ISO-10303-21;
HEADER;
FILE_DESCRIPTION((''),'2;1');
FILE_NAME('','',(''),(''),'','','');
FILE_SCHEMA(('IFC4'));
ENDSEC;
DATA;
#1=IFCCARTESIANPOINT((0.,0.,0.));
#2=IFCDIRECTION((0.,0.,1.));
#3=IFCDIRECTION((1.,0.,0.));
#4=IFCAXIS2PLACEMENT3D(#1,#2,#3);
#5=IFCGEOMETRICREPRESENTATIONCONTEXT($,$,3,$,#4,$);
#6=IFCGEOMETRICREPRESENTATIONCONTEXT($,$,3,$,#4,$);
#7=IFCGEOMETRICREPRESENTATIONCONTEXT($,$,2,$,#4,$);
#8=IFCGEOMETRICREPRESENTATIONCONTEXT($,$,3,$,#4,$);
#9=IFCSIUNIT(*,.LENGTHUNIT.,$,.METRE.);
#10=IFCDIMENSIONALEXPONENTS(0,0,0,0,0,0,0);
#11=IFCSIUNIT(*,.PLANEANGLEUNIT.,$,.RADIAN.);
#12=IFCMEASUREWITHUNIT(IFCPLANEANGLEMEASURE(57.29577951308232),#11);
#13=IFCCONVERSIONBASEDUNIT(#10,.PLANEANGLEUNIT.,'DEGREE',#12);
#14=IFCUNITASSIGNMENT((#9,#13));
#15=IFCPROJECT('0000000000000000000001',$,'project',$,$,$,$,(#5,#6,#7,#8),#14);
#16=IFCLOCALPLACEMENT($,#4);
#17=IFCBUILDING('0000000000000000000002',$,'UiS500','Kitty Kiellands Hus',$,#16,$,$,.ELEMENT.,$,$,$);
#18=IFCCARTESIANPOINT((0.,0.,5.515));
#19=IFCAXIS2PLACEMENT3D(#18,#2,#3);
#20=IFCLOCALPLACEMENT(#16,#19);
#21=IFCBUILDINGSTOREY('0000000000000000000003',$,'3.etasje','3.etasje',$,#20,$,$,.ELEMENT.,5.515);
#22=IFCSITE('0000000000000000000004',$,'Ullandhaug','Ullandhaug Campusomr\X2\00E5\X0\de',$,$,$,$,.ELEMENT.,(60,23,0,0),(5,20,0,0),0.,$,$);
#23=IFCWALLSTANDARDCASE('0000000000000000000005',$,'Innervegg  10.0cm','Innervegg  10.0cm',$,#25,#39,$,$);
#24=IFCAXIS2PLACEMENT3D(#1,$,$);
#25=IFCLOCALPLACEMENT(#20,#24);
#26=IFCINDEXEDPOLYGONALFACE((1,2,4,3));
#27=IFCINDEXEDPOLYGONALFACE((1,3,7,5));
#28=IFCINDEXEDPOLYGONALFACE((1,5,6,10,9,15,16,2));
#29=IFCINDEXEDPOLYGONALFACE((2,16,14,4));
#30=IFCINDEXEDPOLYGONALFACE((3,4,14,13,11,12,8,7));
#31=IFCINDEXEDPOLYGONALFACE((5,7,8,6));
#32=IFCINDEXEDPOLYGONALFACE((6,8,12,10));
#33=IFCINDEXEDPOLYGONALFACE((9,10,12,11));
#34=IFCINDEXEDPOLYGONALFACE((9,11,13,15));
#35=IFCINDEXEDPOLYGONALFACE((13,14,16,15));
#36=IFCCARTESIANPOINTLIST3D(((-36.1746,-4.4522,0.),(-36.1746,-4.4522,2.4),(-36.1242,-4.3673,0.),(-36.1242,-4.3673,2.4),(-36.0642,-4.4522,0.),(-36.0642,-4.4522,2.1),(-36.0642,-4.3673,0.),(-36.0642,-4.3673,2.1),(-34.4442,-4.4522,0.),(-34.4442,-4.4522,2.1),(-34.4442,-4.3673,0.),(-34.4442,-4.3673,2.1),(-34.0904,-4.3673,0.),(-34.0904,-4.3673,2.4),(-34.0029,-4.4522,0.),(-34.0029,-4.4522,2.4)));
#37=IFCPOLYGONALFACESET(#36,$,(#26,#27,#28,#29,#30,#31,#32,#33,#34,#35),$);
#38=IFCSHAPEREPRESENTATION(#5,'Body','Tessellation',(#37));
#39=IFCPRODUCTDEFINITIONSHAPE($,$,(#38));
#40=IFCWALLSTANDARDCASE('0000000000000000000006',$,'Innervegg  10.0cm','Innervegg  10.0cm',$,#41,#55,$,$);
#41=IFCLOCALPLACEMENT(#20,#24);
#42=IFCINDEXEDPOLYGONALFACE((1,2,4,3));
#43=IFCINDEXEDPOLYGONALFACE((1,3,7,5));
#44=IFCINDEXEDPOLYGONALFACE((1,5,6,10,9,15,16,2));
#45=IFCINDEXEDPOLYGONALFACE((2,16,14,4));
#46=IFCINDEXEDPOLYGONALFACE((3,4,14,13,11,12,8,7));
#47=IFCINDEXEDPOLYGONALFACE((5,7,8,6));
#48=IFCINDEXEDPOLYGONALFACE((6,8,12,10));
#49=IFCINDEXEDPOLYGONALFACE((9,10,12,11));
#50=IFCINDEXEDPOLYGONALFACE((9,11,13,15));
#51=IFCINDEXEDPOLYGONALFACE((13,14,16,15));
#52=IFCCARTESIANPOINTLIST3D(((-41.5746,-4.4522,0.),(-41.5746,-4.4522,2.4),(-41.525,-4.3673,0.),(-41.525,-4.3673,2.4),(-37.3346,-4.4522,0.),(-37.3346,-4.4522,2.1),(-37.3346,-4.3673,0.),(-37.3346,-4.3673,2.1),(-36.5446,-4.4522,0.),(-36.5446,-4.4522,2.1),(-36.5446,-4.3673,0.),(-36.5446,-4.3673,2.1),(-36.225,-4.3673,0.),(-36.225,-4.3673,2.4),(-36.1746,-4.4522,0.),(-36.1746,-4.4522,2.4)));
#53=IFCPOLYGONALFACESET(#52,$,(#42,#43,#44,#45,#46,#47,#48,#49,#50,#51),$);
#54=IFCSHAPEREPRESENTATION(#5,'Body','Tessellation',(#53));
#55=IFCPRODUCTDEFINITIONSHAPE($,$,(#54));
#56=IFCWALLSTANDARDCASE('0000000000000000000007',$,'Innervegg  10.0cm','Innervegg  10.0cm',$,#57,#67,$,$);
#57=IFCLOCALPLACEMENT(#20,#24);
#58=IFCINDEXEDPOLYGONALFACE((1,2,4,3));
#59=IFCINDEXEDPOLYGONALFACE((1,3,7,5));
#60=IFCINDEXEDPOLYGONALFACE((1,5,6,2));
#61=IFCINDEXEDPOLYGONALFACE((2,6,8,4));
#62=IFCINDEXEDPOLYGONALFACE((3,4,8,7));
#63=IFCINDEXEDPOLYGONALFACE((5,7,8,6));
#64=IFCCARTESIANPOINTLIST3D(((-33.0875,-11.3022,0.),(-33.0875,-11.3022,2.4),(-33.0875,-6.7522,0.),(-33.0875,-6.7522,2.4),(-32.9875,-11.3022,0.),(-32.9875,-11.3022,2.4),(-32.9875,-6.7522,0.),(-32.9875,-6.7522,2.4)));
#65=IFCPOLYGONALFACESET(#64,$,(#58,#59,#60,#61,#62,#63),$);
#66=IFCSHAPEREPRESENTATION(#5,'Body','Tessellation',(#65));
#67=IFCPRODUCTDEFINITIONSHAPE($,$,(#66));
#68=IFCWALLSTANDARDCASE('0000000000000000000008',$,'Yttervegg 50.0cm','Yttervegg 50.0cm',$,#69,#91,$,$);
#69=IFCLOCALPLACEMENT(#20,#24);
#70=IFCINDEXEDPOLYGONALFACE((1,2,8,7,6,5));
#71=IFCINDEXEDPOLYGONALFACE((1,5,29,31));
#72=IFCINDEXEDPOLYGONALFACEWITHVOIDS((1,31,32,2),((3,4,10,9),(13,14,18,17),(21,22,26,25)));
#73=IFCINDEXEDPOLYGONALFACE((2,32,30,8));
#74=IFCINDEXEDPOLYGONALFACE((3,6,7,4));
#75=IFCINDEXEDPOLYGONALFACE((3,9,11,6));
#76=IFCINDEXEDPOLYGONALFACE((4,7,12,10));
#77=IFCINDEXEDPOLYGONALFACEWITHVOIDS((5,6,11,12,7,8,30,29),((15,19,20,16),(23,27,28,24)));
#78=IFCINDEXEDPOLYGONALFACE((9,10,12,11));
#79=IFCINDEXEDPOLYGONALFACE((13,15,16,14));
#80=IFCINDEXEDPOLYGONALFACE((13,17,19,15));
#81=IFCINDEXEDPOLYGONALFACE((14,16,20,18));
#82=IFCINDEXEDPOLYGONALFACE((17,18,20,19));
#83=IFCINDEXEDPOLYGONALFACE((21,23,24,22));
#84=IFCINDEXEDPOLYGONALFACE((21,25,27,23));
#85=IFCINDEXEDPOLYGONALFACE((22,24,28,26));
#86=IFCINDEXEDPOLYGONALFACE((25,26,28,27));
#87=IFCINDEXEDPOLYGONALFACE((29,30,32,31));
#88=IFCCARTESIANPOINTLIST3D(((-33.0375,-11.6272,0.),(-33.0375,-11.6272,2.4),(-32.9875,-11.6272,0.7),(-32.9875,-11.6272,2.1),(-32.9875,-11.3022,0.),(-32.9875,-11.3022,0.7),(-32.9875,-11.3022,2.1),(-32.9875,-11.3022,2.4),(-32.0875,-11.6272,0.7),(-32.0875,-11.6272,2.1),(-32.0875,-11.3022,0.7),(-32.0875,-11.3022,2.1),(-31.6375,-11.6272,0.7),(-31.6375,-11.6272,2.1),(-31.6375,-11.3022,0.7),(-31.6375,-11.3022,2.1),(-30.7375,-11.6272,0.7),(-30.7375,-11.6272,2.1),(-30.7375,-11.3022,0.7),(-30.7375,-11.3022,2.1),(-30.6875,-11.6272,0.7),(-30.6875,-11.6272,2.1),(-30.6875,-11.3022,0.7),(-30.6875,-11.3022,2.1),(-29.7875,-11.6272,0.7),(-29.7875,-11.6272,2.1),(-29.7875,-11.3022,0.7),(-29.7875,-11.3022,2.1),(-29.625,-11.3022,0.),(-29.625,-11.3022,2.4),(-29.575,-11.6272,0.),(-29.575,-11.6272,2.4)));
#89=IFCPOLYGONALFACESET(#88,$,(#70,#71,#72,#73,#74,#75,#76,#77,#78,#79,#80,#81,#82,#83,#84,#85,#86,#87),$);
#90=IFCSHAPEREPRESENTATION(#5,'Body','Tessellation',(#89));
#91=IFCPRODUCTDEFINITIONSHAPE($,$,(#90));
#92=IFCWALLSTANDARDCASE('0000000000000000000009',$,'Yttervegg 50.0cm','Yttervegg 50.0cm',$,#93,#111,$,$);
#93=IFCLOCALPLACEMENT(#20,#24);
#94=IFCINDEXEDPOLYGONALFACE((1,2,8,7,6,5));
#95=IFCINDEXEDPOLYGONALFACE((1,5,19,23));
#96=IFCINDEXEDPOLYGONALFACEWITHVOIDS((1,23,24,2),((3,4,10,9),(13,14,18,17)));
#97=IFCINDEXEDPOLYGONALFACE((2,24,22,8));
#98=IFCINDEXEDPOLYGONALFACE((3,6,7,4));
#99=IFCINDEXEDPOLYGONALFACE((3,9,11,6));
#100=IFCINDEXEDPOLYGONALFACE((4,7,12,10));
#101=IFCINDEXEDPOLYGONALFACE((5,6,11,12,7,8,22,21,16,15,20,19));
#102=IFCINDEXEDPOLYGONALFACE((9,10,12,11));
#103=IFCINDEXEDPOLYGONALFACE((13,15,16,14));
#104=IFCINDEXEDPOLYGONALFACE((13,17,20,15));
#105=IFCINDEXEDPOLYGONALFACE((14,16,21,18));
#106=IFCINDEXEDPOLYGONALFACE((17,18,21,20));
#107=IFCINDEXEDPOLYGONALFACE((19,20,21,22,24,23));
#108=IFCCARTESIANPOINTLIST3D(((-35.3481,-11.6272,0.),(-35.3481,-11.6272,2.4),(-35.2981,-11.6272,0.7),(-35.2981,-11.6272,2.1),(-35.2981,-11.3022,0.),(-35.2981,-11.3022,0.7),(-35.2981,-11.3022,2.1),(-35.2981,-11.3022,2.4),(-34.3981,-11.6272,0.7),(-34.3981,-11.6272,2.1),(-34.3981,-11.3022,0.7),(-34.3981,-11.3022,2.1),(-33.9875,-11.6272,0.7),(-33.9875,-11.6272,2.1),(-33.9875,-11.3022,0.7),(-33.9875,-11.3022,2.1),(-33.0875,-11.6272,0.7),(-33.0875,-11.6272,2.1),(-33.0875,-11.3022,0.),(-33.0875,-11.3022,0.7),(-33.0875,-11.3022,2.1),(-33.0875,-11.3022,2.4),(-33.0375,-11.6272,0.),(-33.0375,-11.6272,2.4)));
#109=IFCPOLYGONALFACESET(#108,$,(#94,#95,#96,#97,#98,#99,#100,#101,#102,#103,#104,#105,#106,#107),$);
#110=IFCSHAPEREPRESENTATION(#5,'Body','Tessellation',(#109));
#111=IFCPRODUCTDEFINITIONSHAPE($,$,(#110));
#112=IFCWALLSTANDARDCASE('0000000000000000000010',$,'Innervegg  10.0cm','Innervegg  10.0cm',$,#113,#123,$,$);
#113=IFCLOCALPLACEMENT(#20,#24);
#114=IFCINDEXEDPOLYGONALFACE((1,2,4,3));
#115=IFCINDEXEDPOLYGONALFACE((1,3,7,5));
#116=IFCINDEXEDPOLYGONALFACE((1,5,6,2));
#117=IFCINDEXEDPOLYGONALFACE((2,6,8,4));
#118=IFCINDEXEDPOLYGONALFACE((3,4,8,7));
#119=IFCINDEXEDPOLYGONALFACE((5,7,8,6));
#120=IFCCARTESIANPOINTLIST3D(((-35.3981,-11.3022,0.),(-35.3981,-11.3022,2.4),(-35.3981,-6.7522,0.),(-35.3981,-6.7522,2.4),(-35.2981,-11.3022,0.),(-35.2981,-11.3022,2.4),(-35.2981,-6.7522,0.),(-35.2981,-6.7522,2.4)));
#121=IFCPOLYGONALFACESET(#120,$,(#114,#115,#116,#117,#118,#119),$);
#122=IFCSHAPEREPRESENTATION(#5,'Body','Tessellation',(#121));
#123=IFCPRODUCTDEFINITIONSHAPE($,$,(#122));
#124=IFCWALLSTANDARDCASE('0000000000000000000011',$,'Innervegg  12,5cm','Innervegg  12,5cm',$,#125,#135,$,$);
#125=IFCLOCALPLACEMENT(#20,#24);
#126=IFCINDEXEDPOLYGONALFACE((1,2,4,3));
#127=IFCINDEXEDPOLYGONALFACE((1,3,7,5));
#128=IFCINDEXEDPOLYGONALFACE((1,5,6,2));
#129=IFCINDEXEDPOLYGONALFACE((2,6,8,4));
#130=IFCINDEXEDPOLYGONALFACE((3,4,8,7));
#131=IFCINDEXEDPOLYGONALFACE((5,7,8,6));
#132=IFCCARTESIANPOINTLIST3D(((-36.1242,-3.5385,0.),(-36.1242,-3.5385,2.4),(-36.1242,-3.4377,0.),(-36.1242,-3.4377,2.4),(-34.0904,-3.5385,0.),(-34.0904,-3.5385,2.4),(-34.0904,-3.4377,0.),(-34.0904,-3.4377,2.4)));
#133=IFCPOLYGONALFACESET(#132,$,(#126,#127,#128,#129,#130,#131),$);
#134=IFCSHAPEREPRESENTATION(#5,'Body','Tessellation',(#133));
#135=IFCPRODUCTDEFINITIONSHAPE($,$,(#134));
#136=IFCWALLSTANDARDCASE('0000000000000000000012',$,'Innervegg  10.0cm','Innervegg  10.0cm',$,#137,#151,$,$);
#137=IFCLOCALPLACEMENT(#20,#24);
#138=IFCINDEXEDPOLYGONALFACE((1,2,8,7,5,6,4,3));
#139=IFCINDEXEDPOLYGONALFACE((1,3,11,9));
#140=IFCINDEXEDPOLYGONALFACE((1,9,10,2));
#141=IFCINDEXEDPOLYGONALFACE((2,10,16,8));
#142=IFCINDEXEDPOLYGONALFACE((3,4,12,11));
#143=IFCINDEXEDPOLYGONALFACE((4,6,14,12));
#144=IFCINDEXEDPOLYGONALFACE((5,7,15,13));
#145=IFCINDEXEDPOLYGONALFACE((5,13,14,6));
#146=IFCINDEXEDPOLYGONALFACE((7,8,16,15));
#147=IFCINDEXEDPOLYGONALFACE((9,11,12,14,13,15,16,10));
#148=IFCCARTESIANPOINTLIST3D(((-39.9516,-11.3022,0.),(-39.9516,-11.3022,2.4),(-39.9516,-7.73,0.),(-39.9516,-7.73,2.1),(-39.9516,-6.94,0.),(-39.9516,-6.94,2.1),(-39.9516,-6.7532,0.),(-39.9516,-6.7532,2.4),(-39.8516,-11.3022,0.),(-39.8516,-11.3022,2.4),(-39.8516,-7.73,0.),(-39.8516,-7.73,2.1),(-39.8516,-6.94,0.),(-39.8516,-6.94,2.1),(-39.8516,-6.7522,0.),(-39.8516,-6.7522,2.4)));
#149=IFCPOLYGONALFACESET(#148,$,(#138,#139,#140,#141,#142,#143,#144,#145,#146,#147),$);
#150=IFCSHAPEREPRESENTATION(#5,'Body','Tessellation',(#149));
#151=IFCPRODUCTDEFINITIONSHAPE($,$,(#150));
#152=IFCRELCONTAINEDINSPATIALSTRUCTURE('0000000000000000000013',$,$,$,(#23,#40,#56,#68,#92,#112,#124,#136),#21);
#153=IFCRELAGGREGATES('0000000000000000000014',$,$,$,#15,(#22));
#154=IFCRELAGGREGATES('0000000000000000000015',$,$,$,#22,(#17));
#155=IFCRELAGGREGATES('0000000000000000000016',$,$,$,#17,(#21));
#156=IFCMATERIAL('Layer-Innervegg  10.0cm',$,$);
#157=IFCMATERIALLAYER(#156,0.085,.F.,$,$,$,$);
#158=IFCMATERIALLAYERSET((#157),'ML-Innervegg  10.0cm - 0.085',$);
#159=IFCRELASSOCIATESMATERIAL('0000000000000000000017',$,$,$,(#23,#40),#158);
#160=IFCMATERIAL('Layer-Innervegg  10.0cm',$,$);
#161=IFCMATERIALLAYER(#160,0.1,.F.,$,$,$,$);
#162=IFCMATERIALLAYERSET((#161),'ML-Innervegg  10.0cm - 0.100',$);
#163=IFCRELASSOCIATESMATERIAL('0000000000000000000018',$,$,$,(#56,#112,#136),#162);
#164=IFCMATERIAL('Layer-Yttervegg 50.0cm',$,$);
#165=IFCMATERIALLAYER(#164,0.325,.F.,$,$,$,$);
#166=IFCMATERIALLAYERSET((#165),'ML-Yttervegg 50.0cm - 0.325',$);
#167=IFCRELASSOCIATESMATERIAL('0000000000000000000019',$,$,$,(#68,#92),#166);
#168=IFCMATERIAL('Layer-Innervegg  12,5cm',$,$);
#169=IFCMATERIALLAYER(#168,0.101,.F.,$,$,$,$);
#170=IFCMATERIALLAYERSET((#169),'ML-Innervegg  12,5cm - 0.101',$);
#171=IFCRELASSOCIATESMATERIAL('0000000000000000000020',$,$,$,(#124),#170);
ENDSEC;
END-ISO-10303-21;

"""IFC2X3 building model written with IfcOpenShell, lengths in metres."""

from ifc_helpers import new_model, entity, si_unit, converted_unit, frame, origin_with_axes, place, context, project, spatial, polyline, outline, extrude, material, layer, layer_set, layer_usage, element, save


model = new_model("IFC2X3")

# Units and contexts
context_of_model_1 = context(None, 3, world=origin_with_axes())
context_of_model_2 = context(None, 3, world=origin_with_axes())
context_of_model_3 = context(None, 2, world=origin_with_axes())
context_of_model_4 = context(None, 3, world=origin_with_axes())
ifc_project = project(units=[si_unit("LENGTHUNIT", "METRE"), converted_unit("PLANEANGLEUNIT", "DEGREE", entity("IfcPlaneAngleMeasure", 57.29577951308232), si_unit("PLANEANGLEUNIT", "RADIAN"), dimensions=[0, 0, 0, 0, 0, 0, 0])], contexts=[context_of_model_1, context_of_model_2, context_of_model_3, context_of_model_4])

# Site, building, storey
site = spatial("IfcSite", under=ifc_project, Name="Ullandhaug", Description="Ullandhaug Campusområde", CompositionType="ELEMENT", RefLatitude=(60, 23, 0, 0), RefLongitude=(5, 20, 0, 0), RefElevation=0.0)
building_placement = place(None, origin_with_axes())
building = spatial("IfcBuilding", under=site, at=building_placement, Name="UiS500", Description="Kitty Kiellands Hus", CompositionType="ELEMENT")
storey_placement = place(building_placement, frame((0.0, 0.0, 5.515), z_axis=(0.0, 0.0, 1.0), x_axis=(1.0, 0.0, 0.0)))
storey = spatial("IfcBuildingStorey", under=building, at=storey_placement, Name="3.etasje", Description="3.etasje", CompositionType="ELEMENT", Elevation=5.515)

# Shared definitions
ifc_material_1 = material(Name="Layer-Innervegg  10.0cm")
ifc_layer_1 = layer(ifc_material_1, 0.1, ventilated=False)
ifc_layer_set_1 = layer_set([ifc_layer_1], Name="ML-Innervegg  10.0cm - 0.100")
ifc_layer_usage_1 = layer_usage(ifc_layer_set_1, "AXIS2", "POSITIVE", 0.0)

# Walls, openings
ifc_material_2 = material(Name="Layer-Innervegg  10.0cm")
ifc_layer_2 = layer(ifc_material_2, 0.085, ventilated=False)
ifc_layer_set_2 = layer_set([ifc_layer_2], Name="ML-Innervegg  10.0cm - 0.085")
ifc_layer_usage_2 = layer_usage(ifc_layer_set_2, "AXIS2", "POSITIVE", 0.0)
wall_1_placement = place(storey_placement, frame((-34.0904, -4.3673, 0.0), z_axis=(0.0, 0.0, 1.0), x_axis=(-1.0, 0.0, 0.0)))
wall_1 = element("IfcWallStandardCase", 1, at=wall_1_placement, inside=storey, material=ifc_layer_usage_2, Name="Innervegg  10.0cm", Description="Innervegg  10.0cm", context=context_of_model_1, shape_type="SweptSolid", body=[
    extrude(outline(polyline([(0.0, 0.0), (2.0338, 0.0), (2.0842, 0.085), (-0.0875, 0.085), (0.0, 0.0)])), frame((0.0, 0.0, 0.0), z_axis=(0.0, 0.0, 1.0), x_axis=(1.0, 0.0, 0.0)), (0.0, 0.0, 1.0), 2.4),
])
opening_1_placement = place(wall_1_placement, frame((0.3538, 0.085, 0.0), z_axis=(0.0, 0.0, 1.0), x_axis=(1.0, 0.0, 0.0)))
element("IfcOpeningElement", 2, at=opening_1_placement, cuts=wall_1, context=context_of_model_1, shape_type="SweptSolid", body=[
    extrude(outline(polyline([(0.0, 0.0), (2.1, 0.0), (2.1, 1.62), (0.0, 1.62), (0.0, 0.0)])), frame((0.0, 0.0, 0.0), z_axis=(0.0, 1.0, 0.0), x_axis=(0.0, 0.0, 1.0)), (0.0, 0.0, -1.0), 0.085),
])
wall_2_placement = place(storey_placement, frame((-36.225, -4.3673, 0.0), z_axis=(0.0, 0.0, 1.0), x_axis=(-1.0, 0.0, 0.0)))
wall_2 = element("IfcWallStandardCase", 3, at=wall_2_placement, inside=storey, material=ifc_layer_usage_2, Name="Innervegg  10.0cm", Description="Innervegg  10.0cm", context=context_of_model_1, shape_type="SweptSolid", body=[
    extrude(outline(polyline([(0.0, 0.0), (5.3, 0.0), (5.3496, 0.085), (-0.0504, 0.085), (0.0, 0.0)])), frame((0.0, 0.0, 0.0), z_axis=(0.0, 0.0, 1.0), x_axis=(1.0, 0.0, 0.0)), (0.0, 0.0, 1.0), 2.4),
])
opening_2_placement = place(wall_2_placement, frame((0.3196, 0.085, 0.0), z_axis=(0.0, 0.0, 1.0), x_axis=(1.0, 0.0, 0.0)))
element("IfcOpeningElement", 4, at=opening_2_placement, cuts=wall_2, context=context_of_model_1, shape_type="SweptSolid", body=[
    extrude(outline(polyline([(0.0, 0.0), (2.1, 0.0), (2.1, 0.79), (0.0, 0.79), (0.0, 0.0)])), frame((0.0, 0.0, 0.0), z_axis=(0.0, 1.0, 0.0), x_axis=(0.0, 0.0, 1.0)), (0.0, 0.0, -1.0), 0.085),
])

# Wall
wall_3_placement = place(storey_placement, frame((-33.0875, -6.7522, 0.0), z_axis=(0.0, 0.0, 1.0), x_axis=(0.0, -1.0, 0.0)))
element("IfcWallStandardCase", 5, at=wall_3_placement, inside=storey, material=ifc_layer_usage_1, Name="Innervegg  10.0cm", Description="Innervegg  10.0cm", context=context_of_model_1, shape_type="SweptSolid", body=[
    extrude(outline(polyline([(0.0, 0.0), (4.55, 0.0), (4.55, 0.1), (0.0, 0.1), (0.0, 0.0)])), frame((0.0, 0.0, 0.0), z_axis=(0.0, 0.0, 1.0), x_axis=(1.0, 0.0, 0.0)), (0.0, 0.0, 1.0), 2.4),
])

# Walls, openings
ifc_material_3 = material(Name="Layer-Yttervegg 50.0cm")
ifc_layer_3 = layer(ifc_material_3, 0.325, ventilated=False)
ifc_layer_set_3 = layer_set([ifc_layer_3], Name="ML-Yttervegg 50.0cm - 0.325")
ifc_layer_usage_3 = layer_usage(ifc_layer_set_3, "AXIS2", "POSITIVE", 0.0)
wall_4_placement = place(storey_placement, frame((-33.0375, -11.6272, 0.0), z_axis=(0.0, 0.0, 1.0), x_axis=(1.0, 0.0, 0.0)))
wall_4 = element("IfcWallStandardCase", 6, at=wall_4_placement, inside=storey, material=ifc_layer_usage_3, Name="Yttervegg 50.0cm", Description="Yttervegg 50.0cm", context=context_of_model_1, shape_type="SweptSolid", body=[
    extrude(outline(polyline([(0.0, 0.0), (3.4625, 0.0), (3.4125, 0.325), (0.05, 0.325), (0.0, 0.0)])), origin_with_axes(), (0.0, 0.0, 1.0), 2.4),
])
opening_3_placement = place(wall_4_placement, frame((0.05, 0.325, 0.7), z_axis=(0.0, 0.0, 1.0), x_axis=(1.0, 0.0, 0.0)))
element("IfcOpeningElement", 7, at=opening_3_placement, cuts=wall_4, context=context_of_model_1, shape_type="SweptSolid", body=[
    extrude(outline(polyline([(0.0, 0.0), (1.4, 0.0), (1.4, 0.9), (0.0, 0.9), (0.0, 0.0)])), frame((0.0, 0.0, 0.0), z_axis=(0.0, 1.0, 0.0), x_axis=(0.0, 0.0, 1.0)), (0.0, 0.0, -1.0), 0.325),
])
opening_4_placement = place(wall_4_placement, frame((1.4, 0.325, 0.7), z_axis=(0.0, 0.0, 1.0), x_axis=(1.0, 0.0, 0.0)))
element("IfcOpeningElement", 8, at=opening_4_placement, cuts=wall_4, context=context_of_model_1, shape_type="SweptSolid", body=[
    extrude(outline(polyline([(0.0, 0.0), (1.4, 0.0), (1.4, 0.9), (0.0, 0.9), (0.0, 0.0)])), frame((0.0, 0.0, 0.0), z_axis=(0.0, 1.0, 0.0), x_axis=(0.0, 0.0, 1.0)), (0.0, 0.0, -1.0), 0.325),
])
opening_5_placement = place(wall_4_placement, frame((2.35, 0.325, 0.7), z_axis=(0.0, 0.0, 1.0), x_axis=(1.0, 0.0, 0.0)))
element("IfcOpeningElement", 9, at=opening_5_placement, cuts=wall_4, context=context_of_model_1, shape_type="SweptSolid", body=[
    extrude(outline(polyline([(0.0, 0.0), (1.4, 0.0), (1.4, 0.9), (0.0, 0.9), (0.0, 0.0)])), frame((0.0, 0.0, 0.0), z_axis=(0.0, 1.0, 0.0), x_axis=(0.0, 0.0, 1.0)), (0.0, 0.0, -1.0), 0.325),
])
wall_5_placement = place(storey_placement, frame((-35.3481, -11.6272, 0.0), z_axis=(0.0, 0.0, 1.0), x_axis=(1.0, 0.0, 0.0)))
wall_5 = element("IfcWallStandardCase", 10, at=wall_5_placement, inside=storey, material=ifc_layer_usage_3, Name="Yttervegg 50.0cm", Description="Yttervegg 50.0cm", context=context_of_model_1, shape_type="SweptSolid", body=[
    extrude(outline(polyline([(0.0, 0.0), (2.3106, 0.0), (2.2606, 0.325), (0.05, 0.325), (0.0, 0.0)])), origin_with_axes(), (0.0, 0.0, 1.0), 2.4),
])
opening_6_placement = place(wall_5_placement, frame((0.05, 0.325, 0.7), z_axis=(0.0, 0.0, 1.0), x_axis=(1.0, 0.0, 0.0)))
element("IfcOpeningElement", 11, at=opening_6_placement, cuts=wall_5, context=context_of_model_1, shape_type="SweptSolid", body=[
    extrude(outline(polyline([(0.0, 0.0), (1.4, 0.0), (1.4, 0.9), (0.0, 0.9), (0.0, 0.0)])), frame((0.0, 0.0, 0.0), z_axis=(0.0, 1.0, 0.0), x_axis=(0.0, 0.0, 1.0)), (0.0, 0.0, -1.0), 0.325),
])
opening_7_placement = place(wall_5_placement, frame((1.3606, 0.325, 0.7), z_axis=(0.0, 0.0, 1.0), x_axis=(1.0, 0.0, 0.0)))
element("IfcOpeningElement", 12, at=opening_7_placement, cuts=wall_5, context=context_of_model_1, shape_type="SweptSolid", body=[
    extrude(outline(polyline([(0.0, 0.0), (1.4, 0.0), (1.4, 0.9), (0.0, 0.9), (0.0, 0.0)])), frame((0.0, 0.0, 0.0), z_axis=(0.0, 1.0, 0.0), x_axis=(0.0, 0.0, 1.0)), (0.0, 0.0, -1.0), 0.325),
])

# Walls
wall_6_placement = place(storey_placement, frame((-35.3981, -6.7522, 0.0), z_axis=(0.0, 0.0, 1.0), x_axis=(0.0, -1.0, 0.0)))
element("IfcWallStandardCase", 13, at=wall_6_placement, inside=storey, material=ifc_layer_usage_1, Name="Innervegg  10.0cm", Description="Innervegg  10.0cm", context=context_of_model_1, shape_type="SweptSolid", body=[
    extrude(outline(polyline([(0.0, 0.0), (4.55, 0.0), (4.55, 0.1), (0.0, 0.1), (0.0, 0.0)])), frame((0.0, 0.0, 0.0), z_axis=(0.0, 0.0, 1.0), x_axis=(1.0, 0.0, 0.0)), (0.0, 0.0, 1.0), 2.4),
])
ifc_material_4 = material(Name="Layer-Innervegg  12,5cm")
ifc_layer_4 = layer(ifc_material_4, 0.101, ventilated=False)
ifc_layer_set_4 = layer_set([ifc_layer_4], Name="ML-Innervegg  12,5cm - 0.101")
ifc_layer_usage_4 = layer_usage(ifc_layer_set_4, "AXIS2", "POSITIVE", 0.0)
wall_7_placement = place(storey_placement, frame((-36.1242, -3.5385, 0.0), z_axis=(0.0, 0.0, 1.0), x_axis=(1.0, 0.0, 0.0)))
element("IfcWallStandardCase", 14, at=wall_7_placement, inside=storey, material=ifc_layer_usage_4, Name="Innervegg  12,5cm", Description="Innervegg  12,5cm", context=context_of_model_1, shape_type="SweptSolid", body=[
    extrude(outline(polyline([(0.0, 0.0), (2.0338, 0.0), (2.0338, 0.1008), (0.0, 0.1008), (0.0, 0.0)])), origin_with_axes(), (0.0, 0.0, 1.0), 2.4),
])

# Wall, opening
wall_8_placement = place(storey_placement, frame((-39.9516, -6.7532, 0.0), z_axis=(0.0, 0.0, 1.0), x_axis=(0.0, -1.0, 0.0)))
wall_8 = element("IfcWallStandardCase", 15, at=wall_8_placement, inside=storey, material=ifc_layer_usage_1, Name="Innervegg  10.0cm", Description="Innervegg  10.0cm", context=context_of_model_1, shape_type="SweptSolid", body=[
    extrude(outline(polyline([(0.0, 0.0), (4.549, 0.0), (4.549, 0.1), (-0.001, 0.1), (0.0, 0.0)])), frame((0.0, 0.0, 0.0), z_axis=(0.0, 0.0, 1.0), x_axis=(1.0, 0.0, 0.0)), (0.0, 0.0, 1.0), 2.4),
])
opening_8_placement = place(wall_8_placement, frame((0.1867, 0.1, 0.0), z_axis=(0.0, 0.0, 1.0), x_axis=(1.0, 0.0, 0.0)))
element("IfcOpeningElement", 16, at=opening_8_placement, cuts=wall_8, context=context_of_model_1, shape_type="SweptSolid", body=[
    extrude(outline(polyline([(0.0, 0.0), (2.1, 0.0), (2.1, 0.79), (0.0, 0.79), (0.0, 0.0)])), frame((0.0, 0.0, 0.0), z_axis=(0.0, 1.0, 0.0), x_axis=(0.0, 0.0, 1.0)), (0.0, 0.0, -1.0), 0.1),
])

save(model, "model.ifc")
